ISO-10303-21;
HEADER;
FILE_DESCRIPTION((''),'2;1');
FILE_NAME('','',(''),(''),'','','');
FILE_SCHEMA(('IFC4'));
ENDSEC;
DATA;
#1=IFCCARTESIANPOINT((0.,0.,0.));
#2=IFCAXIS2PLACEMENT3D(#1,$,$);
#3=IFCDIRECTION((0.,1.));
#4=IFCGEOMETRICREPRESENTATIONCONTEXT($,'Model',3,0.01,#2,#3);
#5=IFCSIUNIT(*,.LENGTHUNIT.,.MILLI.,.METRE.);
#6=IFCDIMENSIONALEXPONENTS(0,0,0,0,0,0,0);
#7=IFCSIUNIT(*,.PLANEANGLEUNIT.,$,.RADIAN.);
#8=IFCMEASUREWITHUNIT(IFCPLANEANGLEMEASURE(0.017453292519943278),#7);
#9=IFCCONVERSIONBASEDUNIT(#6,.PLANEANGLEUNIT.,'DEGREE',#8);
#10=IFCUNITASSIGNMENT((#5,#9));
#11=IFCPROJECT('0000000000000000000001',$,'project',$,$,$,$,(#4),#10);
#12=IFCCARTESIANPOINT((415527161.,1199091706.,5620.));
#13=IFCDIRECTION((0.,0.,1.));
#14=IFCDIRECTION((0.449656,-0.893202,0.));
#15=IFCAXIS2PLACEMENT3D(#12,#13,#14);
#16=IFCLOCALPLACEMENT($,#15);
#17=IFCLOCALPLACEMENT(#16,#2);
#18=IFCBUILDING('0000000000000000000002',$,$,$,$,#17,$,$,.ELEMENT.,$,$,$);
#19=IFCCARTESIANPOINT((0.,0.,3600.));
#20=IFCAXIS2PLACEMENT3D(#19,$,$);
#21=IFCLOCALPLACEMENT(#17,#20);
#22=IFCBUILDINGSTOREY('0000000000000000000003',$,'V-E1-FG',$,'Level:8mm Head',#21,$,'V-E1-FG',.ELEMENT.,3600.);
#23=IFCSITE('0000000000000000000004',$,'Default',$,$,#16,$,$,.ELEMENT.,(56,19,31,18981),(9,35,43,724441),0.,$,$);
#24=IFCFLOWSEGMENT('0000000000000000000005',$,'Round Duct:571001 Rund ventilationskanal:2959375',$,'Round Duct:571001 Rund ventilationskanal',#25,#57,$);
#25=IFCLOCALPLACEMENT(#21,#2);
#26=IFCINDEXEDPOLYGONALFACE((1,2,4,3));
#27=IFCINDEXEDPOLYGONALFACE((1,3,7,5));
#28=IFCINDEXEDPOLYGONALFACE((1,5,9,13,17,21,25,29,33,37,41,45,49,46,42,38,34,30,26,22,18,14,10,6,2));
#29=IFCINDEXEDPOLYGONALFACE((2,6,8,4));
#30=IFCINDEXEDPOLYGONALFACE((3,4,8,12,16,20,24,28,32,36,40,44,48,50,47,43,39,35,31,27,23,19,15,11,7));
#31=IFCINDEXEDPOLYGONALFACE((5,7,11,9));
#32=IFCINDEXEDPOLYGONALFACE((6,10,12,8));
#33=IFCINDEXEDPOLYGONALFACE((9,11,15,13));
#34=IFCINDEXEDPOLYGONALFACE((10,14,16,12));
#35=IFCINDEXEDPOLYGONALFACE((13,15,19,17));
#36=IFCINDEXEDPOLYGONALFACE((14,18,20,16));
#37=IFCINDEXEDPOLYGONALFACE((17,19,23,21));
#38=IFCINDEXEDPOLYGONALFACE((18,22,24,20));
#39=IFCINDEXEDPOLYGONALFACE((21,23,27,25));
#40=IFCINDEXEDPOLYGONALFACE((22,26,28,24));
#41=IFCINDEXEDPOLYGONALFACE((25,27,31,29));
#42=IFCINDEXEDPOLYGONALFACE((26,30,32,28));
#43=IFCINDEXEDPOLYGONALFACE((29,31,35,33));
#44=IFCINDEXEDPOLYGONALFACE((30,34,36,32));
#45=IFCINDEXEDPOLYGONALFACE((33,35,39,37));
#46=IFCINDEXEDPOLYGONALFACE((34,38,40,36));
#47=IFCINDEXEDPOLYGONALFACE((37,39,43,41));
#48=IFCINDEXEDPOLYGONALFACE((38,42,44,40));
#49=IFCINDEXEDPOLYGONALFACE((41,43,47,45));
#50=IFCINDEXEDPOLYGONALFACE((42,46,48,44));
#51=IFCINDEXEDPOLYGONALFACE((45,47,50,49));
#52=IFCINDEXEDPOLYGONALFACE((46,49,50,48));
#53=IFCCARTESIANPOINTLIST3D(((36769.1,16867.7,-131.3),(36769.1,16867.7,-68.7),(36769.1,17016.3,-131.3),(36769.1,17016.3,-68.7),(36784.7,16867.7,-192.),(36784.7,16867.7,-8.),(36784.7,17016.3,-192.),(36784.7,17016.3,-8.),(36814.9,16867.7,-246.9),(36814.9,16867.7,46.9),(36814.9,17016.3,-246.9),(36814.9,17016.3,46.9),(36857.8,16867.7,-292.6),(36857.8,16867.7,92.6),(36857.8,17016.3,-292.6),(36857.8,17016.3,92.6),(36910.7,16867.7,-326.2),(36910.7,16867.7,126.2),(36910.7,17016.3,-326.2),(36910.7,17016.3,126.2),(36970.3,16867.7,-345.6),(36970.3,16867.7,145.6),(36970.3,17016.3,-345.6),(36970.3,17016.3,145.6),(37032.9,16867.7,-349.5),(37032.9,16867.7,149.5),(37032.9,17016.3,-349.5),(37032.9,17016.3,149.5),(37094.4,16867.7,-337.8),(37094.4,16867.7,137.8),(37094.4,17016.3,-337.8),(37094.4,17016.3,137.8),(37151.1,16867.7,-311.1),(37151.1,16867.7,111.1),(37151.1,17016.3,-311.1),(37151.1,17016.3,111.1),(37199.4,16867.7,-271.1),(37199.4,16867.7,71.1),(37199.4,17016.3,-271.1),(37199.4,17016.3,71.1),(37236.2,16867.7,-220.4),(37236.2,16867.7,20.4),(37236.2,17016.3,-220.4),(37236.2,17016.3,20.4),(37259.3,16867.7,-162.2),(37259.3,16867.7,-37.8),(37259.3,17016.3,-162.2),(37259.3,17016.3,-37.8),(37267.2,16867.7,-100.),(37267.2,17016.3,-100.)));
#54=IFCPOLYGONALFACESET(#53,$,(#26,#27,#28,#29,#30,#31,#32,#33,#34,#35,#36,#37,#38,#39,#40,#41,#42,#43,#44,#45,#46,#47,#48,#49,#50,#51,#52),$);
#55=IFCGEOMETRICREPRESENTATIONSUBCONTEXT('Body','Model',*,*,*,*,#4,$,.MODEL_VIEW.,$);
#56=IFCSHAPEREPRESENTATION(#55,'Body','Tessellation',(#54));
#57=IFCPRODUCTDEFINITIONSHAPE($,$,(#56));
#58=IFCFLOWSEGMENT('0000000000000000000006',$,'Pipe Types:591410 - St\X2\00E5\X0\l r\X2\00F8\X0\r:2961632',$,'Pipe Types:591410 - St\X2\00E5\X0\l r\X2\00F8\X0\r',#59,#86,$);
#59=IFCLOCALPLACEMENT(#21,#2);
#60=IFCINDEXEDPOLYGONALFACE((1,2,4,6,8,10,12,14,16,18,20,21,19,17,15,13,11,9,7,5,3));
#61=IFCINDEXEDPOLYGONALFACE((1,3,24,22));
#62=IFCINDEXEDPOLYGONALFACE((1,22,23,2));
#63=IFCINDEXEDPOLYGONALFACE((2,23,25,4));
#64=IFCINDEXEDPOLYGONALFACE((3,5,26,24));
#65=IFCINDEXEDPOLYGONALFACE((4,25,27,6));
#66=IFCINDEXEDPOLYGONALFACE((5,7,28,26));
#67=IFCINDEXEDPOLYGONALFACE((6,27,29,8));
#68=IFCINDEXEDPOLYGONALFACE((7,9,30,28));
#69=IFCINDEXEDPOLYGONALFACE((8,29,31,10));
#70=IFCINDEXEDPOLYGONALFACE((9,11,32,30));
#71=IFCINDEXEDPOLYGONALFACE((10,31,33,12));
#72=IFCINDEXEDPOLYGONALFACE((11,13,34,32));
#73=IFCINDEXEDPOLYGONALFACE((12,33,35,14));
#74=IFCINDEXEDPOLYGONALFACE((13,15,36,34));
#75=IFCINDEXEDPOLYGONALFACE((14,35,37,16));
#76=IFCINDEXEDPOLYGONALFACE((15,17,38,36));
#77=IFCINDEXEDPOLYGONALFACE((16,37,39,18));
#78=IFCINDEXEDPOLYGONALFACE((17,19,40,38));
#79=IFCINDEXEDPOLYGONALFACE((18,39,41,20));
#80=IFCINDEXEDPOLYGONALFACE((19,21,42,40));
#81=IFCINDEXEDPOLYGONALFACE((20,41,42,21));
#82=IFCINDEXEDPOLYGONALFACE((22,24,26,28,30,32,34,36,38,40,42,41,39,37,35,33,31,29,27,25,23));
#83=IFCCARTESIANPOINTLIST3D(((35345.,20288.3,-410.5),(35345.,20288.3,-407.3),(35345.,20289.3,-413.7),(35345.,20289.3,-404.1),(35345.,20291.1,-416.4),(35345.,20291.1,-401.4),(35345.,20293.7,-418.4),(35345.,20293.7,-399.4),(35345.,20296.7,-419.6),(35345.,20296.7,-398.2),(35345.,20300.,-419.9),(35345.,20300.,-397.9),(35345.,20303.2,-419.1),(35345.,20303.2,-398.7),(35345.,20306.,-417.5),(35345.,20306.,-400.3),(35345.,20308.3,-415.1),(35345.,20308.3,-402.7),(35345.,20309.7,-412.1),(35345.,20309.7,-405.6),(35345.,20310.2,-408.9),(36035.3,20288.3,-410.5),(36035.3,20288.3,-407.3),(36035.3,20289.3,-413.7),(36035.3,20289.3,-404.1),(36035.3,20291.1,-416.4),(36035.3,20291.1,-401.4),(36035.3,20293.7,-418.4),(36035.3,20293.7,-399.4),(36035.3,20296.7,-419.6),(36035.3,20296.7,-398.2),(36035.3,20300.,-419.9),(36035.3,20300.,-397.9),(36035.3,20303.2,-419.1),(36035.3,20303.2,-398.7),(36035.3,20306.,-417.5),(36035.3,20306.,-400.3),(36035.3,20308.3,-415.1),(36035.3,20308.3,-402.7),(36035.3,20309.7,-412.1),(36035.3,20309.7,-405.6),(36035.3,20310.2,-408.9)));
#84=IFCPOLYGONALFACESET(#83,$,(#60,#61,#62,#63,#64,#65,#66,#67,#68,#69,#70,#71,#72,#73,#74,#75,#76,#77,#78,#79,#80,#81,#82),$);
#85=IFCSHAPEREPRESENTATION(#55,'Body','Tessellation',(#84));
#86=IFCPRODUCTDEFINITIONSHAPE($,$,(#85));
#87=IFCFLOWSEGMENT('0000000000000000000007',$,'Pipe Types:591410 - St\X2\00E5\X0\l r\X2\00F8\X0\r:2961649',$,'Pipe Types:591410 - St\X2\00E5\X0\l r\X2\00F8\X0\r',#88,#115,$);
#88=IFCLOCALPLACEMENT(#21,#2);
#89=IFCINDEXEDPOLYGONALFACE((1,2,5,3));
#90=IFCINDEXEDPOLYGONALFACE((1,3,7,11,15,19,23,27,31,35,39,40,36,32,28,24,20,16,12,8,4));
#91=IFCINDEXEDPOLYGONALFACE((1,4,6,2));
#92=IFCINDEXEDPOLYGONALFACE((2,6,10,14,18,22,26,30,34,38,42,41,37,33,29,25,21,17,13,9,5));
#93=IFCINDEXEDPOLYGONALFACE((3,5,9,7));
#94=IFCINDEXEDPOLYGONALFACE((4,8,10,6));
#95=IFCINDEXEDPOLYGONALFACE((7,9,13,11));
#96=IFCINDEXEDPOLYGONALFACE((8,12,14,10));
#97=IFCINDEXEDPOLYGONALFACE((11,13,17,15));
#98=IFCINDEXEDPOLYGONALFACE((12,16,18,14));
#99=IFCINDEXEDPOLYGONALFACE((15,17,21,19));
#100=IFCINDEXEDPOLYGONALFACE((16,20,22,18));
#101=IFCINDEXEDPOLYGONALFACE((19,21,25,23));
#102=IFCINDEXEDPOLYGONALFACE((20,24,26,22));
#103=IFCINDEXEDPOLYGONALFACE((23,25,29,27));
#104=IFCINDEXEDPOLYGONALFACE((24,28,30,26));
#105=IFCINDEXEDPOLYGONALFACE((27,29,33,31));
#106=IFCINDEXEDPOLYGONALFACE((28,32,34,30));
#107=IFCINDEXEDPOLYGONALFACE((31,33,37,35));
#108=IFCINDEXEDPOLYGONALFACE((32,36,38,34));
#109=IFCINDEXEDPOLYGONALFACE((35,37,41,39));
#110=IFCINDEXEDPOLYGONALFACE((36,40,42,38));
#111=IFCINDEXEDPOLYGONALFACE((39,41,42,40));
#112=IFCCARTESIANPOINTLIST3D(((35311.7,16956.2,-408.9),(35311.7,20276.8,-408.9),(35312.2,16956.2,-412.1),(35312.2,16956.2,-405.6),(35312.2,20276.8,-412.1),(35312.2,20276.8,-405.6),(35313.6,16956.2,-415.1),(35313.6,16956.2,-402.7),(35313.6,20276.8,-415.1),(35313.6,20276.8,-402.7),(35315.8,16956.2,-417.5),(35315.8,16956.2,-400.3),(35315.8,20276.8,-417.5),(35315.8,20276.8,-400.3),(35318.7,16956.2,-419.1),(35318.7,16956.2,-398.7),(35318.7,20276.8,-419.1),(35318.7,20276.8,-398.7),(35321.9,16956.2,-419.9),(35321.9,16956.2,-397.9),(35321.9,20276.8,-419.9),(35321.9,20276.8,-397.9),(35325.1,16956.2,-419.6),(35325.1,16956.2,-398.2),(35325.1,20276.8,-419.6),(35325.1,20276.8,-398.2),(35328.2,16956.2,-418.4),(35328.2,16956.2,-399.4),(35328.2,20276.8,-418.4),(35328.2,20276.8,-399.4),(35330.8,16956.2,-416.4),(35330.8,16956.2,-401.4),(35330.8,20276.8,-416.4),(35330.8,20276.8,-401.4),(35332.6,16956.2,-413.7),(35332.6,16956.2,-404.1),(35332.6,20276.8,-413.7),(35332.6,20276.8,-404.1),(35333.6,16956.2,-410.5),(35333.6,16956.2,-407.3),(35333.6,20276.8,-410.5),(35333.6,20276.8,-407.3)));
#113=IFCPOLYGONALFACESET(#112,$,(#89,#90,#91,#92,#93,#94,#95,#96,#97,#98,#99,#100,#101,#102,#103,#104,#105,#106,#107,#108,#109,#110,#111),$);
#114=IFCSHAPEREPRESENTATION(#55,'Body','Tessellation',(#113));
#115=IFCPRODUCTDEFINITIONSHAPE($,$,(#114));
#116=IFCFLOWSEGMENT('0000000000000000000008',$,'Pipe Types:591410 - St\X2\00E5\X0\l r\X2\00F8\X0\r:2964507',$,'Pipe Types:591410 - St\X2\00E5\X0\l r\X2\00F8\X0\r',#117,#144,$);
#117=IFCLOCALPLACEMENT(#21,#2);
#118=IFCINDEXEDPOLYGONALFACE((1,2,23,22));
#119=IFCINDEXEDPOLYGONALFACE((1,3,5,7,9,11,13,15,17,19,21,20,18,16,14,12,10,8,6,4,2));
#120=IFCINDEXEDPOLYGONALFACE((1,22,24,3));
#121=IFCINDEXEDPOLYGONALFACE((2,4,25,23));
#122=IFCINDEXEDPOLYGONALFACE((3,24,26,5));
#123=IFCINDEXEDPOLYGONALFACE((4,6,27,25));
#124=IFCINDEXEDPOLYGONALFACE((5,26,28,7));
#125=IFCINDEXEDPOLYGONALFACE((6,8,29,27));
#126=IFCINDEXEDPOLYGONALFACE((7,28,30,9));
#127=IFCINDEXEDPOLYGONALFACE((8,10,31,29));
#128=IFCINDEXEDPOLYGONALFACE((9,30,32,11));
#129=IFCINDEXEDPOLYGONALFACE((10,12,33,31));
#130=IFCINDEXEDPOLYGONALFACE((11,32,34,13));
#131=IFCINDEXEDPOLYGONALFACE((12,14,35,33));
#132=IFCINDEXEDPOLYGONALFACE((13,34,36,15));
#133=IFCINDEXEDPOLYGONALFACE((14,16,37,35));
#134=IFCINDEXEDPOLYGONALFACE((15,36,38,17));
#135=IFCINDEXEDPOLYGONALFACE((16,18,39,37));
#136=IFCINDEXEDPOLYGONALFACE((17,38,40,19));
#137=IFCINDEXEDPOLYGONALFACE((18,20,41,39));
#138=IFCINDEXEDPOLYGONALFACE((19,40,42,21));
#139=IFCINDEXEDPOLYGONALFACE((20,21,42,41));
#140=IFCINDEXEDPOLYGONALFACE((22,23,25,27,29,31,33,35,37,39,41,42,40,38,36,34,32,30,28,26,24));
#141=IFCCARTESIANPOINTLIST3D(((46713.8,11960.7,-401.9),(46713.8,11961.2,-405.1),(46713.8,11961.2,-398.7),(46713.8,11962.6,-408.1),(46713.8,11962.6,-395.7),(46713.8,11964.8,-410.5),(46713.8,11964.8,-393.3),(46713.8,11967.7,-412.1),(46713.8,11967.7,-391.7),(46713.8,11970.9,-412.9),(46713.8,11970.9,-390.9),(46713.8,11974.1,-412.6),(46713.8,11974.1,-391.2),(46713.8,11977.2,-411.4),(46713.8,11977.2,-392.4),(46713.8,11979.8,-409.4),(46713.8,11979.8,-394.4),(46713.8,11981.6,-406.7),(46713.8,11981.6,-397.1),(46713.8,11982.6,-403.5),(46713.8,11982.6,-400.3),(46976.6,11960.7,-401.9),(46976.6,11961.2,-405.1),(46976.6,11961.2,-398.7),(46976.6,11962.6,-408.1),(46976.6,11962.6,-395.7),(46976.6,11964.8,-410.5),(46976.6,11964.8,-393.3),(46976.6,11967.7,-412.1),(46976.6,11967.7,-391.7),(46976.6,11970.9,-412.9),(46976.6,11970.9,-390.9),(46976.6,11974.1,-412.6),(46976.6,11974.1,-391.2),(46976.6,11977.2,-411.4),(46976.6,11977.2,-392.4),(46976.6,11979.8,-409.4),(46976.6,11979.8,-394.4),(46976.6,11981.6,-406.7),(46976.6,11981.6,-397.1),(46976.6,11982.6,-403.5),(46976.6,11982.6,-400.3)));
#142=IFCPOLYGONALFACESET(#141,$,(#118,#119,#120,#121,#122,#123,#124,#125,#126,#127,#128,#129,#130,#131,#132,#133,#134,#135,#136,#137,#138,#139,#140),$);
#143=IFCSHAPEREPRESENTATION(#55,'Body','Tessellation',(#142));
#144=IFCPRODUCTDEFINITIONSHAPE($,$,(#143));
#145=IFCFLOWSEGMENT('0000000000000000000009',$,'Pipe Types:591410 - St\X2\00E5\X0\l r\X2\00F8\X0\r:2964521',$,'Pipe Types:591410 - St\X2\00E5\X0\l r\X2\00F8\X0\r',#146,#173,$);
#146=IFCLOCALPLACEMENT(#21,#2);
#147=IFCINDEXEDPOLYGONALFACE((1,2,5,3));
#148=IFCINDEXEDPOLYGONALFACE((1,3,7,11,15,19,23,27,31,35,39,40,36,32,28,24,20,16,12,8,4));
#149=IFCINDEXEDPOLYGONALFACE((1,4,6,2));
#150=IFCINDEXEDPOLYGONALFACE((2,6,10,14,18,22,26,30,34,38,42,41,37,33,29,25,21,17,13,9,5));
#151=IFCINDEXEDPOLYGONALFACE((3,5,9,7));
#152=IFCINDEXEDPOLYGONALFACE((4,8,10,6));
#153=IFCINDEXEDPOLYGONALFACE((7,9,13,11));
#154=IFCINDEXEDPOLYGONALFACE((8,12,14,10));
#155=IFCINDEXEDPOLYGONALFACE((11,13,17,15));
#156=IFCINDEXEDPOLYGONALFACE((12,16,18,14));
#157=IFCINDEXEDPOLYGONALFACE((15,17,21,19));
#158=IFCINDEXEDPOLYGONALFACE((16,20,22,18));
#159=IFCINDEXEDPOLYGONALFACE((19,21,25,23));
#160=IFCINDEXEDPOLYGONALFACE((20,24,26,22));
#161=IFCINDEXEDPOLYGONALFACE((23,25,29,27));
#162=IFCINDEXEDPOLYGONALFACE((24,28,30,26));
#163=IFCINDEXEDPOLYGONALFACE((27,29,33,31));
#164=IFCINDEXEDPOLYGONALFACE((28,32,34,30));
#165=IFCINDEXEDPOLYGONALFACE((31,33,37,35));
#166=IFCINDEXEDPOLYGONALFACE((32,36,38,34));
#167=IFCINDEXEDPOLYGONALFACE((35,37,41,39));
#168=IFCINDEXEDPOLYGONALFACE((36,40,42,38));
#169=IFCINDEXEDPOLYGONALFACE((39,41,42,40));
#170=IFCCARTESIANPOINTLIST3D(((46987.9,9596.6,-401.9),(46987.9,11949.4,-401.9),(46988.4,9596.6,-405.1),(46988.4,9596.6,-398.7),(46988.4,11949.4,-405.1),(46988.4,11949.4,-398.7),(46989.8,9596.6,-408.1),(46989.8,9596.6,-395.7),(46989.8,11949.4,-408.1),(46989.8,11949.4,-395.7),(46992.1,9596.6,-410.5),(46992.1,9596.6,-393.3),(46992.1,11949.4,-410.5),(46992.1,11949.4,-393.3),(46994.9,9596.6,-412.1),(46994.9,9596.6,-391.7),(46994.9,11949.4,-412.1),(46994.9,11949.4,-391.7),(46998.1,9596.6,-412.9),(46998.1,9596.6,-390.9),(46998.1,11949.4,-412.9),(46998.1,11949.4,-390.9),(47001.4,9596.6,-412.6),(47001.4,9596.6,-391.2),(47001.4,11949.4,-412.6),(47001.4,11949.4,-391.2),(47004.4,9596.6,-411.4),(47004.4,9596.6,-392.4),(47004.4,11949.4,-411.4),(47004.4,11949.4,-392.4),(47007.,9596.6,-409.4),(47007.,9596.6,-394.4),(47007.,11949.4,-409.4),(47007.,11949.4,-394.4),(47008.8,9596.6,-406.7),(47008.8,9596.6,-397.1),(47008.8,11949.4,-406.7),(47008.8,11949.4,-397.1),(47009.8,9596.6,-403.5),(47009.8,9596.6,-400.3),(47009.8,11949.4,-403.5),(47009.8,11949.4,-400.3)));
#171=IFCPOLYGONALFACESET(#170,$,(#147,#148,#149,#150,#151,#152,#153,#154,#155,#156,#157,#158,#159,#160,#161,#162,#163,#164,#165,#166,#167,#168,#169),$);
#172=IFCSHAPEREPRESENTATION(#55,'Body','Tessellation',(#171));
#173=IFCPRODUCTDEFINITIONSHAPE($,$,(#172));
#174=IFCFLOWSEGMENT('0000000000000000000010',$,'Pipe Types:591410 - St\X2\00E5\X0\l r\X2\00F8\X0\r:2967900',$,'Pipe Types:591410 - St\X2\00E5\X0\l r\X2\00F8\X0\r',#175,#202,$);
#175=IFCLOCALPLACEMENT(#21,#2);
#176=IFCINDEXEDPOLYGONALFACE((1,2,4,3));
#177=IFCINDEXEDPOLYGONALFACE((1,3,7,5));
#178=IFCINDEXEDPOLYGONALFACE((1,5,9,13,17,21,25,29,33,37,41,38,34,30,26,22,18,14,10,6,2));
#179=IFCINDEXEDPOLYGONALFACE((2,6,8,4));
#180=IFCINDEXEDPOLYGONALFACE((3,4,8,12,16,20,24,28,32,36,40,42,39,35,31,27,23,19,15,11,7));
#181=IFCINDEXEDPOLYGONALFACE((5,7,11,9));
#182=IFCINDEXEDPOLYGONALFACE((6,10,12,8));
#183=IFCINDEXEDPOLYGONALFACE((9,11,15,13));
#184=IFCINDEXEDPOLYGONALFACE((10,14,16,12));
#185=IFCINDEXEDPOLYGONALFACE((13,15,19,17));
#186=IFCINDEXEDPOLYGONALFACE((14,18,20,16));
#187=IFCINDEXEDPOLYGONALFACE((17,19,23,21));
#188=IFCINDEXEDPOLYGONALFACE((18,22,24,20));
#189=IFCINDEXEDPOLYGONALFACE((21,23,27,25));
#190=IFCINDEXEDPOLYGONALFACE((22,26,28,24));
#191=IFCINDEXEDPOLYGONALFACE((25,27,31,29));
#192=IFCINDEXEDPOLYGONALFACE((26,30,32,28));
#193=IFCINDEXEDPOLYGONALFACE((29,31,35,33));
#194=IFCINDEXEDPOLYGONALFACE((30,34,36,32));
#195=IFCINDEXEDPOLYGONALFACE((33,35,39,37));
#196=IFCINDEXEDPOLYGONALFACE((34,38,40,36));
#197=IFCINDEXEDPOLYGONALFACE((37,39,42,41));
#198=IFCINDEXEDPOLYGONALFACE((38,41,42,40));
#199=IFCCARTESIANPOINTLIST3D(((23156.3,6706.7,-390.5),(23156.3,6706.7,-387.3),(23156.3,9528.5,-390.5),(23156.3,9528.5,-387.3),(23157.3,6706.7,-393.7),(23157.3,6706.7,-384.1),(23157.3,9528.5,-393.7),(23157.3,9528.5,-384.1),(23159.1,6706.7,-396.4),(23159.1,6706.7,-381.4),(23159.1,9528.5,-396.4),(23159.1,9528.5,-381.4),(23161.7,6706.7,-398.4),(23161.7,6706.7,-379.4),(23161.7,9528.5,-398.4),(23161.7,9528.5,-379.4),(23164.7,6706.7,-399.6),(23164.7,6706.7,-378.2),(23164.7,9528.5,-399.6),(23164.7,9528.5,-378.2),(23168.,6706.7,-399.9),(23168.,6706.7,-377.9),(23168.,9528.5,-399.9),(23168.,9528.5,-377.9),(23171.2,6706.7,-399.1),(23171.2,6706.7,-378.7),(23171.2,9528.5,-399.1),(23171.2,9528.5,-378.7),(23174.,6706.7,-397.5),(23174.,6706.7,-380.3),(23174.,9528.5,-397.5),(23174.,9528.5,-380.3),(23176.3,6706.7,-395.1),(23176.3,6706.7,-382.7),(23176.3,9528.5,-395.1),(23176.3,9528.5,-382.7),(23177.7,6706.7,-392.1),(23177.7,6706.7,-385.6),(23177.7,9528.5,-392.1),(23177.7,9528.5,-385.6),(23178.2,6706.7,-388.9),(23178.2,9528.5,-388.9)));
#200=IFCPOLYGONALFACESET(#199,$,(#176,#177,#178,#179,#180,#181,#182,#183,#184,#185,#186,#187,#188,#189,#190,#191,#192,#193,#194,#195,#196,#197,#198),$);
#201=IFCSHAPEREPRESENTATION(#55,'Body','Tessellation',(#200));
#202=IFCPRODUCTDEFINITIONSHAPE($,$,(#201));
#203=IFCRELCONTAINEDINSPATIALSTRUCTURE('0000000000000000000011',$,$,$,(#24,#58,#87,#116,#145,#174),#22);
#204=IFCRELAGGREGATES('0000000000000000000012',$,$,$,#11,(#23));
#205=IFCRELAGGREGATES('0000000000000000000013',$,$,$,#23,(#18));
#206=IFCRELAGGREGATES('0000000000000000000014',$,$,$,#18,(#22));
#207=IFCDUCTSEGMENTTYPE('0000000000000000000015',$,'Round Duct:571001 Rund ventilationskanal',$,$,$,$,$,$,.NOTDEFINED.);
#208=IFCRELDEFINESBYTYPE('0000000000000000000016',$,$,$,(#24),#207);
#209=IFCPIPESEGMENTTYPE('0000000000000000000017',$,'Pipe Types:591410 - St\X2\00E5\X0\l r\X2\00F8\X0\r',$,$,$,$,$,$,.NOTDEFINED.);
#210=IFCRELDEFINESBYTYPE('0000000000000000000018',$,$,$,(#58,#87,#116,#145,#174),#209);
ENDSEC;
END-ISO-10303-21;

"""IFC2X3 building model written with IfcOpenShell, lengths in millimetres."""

from ifc_helpers import new_model, entity, si_unit, converted_unit, direction, frame, frame_2d, origin, origin_2d_with_axis, place, context, subcontext, project, spatial, circle, extrude, type_object, element, save


model = new_model("IFC2X3")

# Units and contexts
model_context = context("Model", 3, precision=0.01, world=origin(), true_north=direction((0.0, 1.0)))
body_context = subcontext(model_context, "Body", "Model", "MODEL_VIEW")
ifc_project = project(units=[si_unit("LENGTHUNIT", "METRE", prefix="MILLI"), converted_unit("PLANEANGLEUNIT", "DEGREE", entity("IfcPlaneAngleMeasure", 0.017453292519943278), si_unit("PLANEANGLEUNIT", "RADIAN"), dimensions=[0, 0, 0, 0, 0, 0, 0])], contexts=[model_context])

# Site, building, storey
site_placement = place(None, frame((415527161.0, 1199091706.0, 5620.0), z_axis=(0.0, 0.0, 1.0), x_axis=(0.449656, -0.893202, 0.0)))
site = spatial("IfcSite", under=ifc_project, at=site_placement, Name="Default", CompositionType="ELEMENT", RefLatitude=(56, 19, 31, 18981), RefLongitude=(9, 35, 43, 724441), RefElevation=0.0)
building_placement = place(site_placement, origin())
building = spatial("IfcBuilding", under=site, at=building_placement, CompositionType="ELEMENT")
storey_placement = place(building_placement, frame((0.0, 0.0, 3600.0)))
storey = spatial("IfcBuildingStorey", under=building, at=storey_placement, Name="V-E1-FG", ObjectType="Level:8mm Head", LongName="V-E1-FG", CompositionType="ELEMENT", Elevation=3600.0)

# Flow segments
duct_segment_type = type_object("IfcDuctSegmentType", Name="Round Duct:571001 Rund ventilationskanal", PredefinedType="NOTDEFINED")
flow_segment_1_placement = place(storey_placement, origin())
element("IfcFlowSegment", 1, at=flow_segment_1_placement, inside=storey, type_object=duct_segment_type, Name="Round Duct:571001 Rund ventilationskanal:2959375", ObjectType="Round Duct:571001 Rund ventilationskanal", context=body_context, shape_type="SweptSolid", body=[
    extrude(circle(Radius=250.0, at=origin_2d_with_axis()), frame((37017.2, 16867.7, -100.0), z_axis=(0.0, 1.0, 0.0), x_axis=(1.0, 0.0, 0.0)), (0.0, 0.0, 1.0), 148.6),
])
pipe_segment_type_1 = type_object("IfcPipeSegmentType", Name="Pipe Types:591410 - Stål rør", PredefinedType="NOTDEFINED")
flow_segment_2_placement = place(storey_placement, origin())
element("IfcFlowSegment", 2, at=flow_segment_2_placement, inside=storey, type_object=pipe_segment_type_1, Name="Pipe Types:591410 - Stål rør:2961632", ObjectType="Pipe Types:591410 - Stål rør", context=body_context, shape_type="SweptSolid", body=[
    extrude(circle(Radius=11.0, at=frame_2d((0.0, 0.0), x_axis=(1.0, 0.0))), frame((35345.0, 20299.2, -408.9), z_axis=(1.0, 0.0, 0.0), x_axis=(0.0, 1.0, 0.0)), (0.0, 0.0, 1.0), 690.3),
])
flow_segment_3_placement = place(storey_placement, origin())
element("IfcFlowSegment", 3, at=flow_segment_3_placement, inside=storey, type_object=pipe_segment_type_1, Name="Pipe Types:591410 - Stål rør:2961649", ObjectType="Pipe Types:591410 - Stål rør", context=body_context, shape_type="SweptSolid", body=[
    extrude(circle(Radius=11.0, at=frame_2d((0.0, 0.0), x_axis=(1.0, 0.0))), frame((35322.7, 16956.2, -408.9), z_axis=(0.0, 1.0, 0.0), x_axis=(-1.0, 0.0, 0.0)), (0.0, 0.0, 1.0), 3320.7),
])
flow_segment_4_placement = place(storey_placement, origin())
element("IfcFlowSegment", 4, at=flow_segment_4_placement, inside=storey, type_object=pipe_segment_type_1, Name="Pipe Types:591410 - Stål rør:2964507", ObjectType="Pipe Types:591410 - Stål rør", context=body_context, shape_type="SweptSolid", body=[
    extrude(circle(Radius=11.0, at=origin_2d_with_axis()), frame((46713.8, 11971.7, -401.9), z_axis=(1.0, 0.0, 0.0), x_axis=(0.0, -1.0, 0.0)), (0.0, 0.0, 1.0), 262.8),
])
flow_segment_5_placement = place(storey_placement, origin())
element("IfcFlowSegment", 5, at=flow_segment_5_placement, inside=storey, type_object=pipe_segment_type_1, Name="Pipe Types:591410 - Stål rør:2964521", ObjectType="Pipe Types:591410 - Stål rør", context=body_context, shape_type="SweptSolid", body=[
    extrude(circle(Radius=11.0, at=frame_2d((0.0, 0.0), x_axis=(1.0, 0.0))), frame((46998.9, 9596.6, -401.9), z_axis=(0.0, 1.0, 0.0), x_axis=(-1.0, 0.0, 0.0)), (0.0, 0.0, 1.0), 2352.8),
])
flow_segment_6_placement = place(storey_placement, origin())
element("IfcFlowSegment", 6, at=flow_segment_6_placement, inside=storey, type_object=pipe_segment_type_1, Name="Pipe Types:591410 - Stål rør:2967900", ObjectType="Pipe Types:591410 - Stål rør", context=body_context, shape_type="SweptSolid", body=[
    extrude(circle(Radius=11.0, at=frame_2d((0.0, 0.0), x_axis=(1.0, 0.0))), frame((23167.2, 6706.7, -388.9), z_axis=(0.0, 1.0, 0.0), x_axis=(1.0, 0.0, 0.0)), (0.0, 0.0, 1.0), 2821.9),
])

save(model, "model.ifc")
